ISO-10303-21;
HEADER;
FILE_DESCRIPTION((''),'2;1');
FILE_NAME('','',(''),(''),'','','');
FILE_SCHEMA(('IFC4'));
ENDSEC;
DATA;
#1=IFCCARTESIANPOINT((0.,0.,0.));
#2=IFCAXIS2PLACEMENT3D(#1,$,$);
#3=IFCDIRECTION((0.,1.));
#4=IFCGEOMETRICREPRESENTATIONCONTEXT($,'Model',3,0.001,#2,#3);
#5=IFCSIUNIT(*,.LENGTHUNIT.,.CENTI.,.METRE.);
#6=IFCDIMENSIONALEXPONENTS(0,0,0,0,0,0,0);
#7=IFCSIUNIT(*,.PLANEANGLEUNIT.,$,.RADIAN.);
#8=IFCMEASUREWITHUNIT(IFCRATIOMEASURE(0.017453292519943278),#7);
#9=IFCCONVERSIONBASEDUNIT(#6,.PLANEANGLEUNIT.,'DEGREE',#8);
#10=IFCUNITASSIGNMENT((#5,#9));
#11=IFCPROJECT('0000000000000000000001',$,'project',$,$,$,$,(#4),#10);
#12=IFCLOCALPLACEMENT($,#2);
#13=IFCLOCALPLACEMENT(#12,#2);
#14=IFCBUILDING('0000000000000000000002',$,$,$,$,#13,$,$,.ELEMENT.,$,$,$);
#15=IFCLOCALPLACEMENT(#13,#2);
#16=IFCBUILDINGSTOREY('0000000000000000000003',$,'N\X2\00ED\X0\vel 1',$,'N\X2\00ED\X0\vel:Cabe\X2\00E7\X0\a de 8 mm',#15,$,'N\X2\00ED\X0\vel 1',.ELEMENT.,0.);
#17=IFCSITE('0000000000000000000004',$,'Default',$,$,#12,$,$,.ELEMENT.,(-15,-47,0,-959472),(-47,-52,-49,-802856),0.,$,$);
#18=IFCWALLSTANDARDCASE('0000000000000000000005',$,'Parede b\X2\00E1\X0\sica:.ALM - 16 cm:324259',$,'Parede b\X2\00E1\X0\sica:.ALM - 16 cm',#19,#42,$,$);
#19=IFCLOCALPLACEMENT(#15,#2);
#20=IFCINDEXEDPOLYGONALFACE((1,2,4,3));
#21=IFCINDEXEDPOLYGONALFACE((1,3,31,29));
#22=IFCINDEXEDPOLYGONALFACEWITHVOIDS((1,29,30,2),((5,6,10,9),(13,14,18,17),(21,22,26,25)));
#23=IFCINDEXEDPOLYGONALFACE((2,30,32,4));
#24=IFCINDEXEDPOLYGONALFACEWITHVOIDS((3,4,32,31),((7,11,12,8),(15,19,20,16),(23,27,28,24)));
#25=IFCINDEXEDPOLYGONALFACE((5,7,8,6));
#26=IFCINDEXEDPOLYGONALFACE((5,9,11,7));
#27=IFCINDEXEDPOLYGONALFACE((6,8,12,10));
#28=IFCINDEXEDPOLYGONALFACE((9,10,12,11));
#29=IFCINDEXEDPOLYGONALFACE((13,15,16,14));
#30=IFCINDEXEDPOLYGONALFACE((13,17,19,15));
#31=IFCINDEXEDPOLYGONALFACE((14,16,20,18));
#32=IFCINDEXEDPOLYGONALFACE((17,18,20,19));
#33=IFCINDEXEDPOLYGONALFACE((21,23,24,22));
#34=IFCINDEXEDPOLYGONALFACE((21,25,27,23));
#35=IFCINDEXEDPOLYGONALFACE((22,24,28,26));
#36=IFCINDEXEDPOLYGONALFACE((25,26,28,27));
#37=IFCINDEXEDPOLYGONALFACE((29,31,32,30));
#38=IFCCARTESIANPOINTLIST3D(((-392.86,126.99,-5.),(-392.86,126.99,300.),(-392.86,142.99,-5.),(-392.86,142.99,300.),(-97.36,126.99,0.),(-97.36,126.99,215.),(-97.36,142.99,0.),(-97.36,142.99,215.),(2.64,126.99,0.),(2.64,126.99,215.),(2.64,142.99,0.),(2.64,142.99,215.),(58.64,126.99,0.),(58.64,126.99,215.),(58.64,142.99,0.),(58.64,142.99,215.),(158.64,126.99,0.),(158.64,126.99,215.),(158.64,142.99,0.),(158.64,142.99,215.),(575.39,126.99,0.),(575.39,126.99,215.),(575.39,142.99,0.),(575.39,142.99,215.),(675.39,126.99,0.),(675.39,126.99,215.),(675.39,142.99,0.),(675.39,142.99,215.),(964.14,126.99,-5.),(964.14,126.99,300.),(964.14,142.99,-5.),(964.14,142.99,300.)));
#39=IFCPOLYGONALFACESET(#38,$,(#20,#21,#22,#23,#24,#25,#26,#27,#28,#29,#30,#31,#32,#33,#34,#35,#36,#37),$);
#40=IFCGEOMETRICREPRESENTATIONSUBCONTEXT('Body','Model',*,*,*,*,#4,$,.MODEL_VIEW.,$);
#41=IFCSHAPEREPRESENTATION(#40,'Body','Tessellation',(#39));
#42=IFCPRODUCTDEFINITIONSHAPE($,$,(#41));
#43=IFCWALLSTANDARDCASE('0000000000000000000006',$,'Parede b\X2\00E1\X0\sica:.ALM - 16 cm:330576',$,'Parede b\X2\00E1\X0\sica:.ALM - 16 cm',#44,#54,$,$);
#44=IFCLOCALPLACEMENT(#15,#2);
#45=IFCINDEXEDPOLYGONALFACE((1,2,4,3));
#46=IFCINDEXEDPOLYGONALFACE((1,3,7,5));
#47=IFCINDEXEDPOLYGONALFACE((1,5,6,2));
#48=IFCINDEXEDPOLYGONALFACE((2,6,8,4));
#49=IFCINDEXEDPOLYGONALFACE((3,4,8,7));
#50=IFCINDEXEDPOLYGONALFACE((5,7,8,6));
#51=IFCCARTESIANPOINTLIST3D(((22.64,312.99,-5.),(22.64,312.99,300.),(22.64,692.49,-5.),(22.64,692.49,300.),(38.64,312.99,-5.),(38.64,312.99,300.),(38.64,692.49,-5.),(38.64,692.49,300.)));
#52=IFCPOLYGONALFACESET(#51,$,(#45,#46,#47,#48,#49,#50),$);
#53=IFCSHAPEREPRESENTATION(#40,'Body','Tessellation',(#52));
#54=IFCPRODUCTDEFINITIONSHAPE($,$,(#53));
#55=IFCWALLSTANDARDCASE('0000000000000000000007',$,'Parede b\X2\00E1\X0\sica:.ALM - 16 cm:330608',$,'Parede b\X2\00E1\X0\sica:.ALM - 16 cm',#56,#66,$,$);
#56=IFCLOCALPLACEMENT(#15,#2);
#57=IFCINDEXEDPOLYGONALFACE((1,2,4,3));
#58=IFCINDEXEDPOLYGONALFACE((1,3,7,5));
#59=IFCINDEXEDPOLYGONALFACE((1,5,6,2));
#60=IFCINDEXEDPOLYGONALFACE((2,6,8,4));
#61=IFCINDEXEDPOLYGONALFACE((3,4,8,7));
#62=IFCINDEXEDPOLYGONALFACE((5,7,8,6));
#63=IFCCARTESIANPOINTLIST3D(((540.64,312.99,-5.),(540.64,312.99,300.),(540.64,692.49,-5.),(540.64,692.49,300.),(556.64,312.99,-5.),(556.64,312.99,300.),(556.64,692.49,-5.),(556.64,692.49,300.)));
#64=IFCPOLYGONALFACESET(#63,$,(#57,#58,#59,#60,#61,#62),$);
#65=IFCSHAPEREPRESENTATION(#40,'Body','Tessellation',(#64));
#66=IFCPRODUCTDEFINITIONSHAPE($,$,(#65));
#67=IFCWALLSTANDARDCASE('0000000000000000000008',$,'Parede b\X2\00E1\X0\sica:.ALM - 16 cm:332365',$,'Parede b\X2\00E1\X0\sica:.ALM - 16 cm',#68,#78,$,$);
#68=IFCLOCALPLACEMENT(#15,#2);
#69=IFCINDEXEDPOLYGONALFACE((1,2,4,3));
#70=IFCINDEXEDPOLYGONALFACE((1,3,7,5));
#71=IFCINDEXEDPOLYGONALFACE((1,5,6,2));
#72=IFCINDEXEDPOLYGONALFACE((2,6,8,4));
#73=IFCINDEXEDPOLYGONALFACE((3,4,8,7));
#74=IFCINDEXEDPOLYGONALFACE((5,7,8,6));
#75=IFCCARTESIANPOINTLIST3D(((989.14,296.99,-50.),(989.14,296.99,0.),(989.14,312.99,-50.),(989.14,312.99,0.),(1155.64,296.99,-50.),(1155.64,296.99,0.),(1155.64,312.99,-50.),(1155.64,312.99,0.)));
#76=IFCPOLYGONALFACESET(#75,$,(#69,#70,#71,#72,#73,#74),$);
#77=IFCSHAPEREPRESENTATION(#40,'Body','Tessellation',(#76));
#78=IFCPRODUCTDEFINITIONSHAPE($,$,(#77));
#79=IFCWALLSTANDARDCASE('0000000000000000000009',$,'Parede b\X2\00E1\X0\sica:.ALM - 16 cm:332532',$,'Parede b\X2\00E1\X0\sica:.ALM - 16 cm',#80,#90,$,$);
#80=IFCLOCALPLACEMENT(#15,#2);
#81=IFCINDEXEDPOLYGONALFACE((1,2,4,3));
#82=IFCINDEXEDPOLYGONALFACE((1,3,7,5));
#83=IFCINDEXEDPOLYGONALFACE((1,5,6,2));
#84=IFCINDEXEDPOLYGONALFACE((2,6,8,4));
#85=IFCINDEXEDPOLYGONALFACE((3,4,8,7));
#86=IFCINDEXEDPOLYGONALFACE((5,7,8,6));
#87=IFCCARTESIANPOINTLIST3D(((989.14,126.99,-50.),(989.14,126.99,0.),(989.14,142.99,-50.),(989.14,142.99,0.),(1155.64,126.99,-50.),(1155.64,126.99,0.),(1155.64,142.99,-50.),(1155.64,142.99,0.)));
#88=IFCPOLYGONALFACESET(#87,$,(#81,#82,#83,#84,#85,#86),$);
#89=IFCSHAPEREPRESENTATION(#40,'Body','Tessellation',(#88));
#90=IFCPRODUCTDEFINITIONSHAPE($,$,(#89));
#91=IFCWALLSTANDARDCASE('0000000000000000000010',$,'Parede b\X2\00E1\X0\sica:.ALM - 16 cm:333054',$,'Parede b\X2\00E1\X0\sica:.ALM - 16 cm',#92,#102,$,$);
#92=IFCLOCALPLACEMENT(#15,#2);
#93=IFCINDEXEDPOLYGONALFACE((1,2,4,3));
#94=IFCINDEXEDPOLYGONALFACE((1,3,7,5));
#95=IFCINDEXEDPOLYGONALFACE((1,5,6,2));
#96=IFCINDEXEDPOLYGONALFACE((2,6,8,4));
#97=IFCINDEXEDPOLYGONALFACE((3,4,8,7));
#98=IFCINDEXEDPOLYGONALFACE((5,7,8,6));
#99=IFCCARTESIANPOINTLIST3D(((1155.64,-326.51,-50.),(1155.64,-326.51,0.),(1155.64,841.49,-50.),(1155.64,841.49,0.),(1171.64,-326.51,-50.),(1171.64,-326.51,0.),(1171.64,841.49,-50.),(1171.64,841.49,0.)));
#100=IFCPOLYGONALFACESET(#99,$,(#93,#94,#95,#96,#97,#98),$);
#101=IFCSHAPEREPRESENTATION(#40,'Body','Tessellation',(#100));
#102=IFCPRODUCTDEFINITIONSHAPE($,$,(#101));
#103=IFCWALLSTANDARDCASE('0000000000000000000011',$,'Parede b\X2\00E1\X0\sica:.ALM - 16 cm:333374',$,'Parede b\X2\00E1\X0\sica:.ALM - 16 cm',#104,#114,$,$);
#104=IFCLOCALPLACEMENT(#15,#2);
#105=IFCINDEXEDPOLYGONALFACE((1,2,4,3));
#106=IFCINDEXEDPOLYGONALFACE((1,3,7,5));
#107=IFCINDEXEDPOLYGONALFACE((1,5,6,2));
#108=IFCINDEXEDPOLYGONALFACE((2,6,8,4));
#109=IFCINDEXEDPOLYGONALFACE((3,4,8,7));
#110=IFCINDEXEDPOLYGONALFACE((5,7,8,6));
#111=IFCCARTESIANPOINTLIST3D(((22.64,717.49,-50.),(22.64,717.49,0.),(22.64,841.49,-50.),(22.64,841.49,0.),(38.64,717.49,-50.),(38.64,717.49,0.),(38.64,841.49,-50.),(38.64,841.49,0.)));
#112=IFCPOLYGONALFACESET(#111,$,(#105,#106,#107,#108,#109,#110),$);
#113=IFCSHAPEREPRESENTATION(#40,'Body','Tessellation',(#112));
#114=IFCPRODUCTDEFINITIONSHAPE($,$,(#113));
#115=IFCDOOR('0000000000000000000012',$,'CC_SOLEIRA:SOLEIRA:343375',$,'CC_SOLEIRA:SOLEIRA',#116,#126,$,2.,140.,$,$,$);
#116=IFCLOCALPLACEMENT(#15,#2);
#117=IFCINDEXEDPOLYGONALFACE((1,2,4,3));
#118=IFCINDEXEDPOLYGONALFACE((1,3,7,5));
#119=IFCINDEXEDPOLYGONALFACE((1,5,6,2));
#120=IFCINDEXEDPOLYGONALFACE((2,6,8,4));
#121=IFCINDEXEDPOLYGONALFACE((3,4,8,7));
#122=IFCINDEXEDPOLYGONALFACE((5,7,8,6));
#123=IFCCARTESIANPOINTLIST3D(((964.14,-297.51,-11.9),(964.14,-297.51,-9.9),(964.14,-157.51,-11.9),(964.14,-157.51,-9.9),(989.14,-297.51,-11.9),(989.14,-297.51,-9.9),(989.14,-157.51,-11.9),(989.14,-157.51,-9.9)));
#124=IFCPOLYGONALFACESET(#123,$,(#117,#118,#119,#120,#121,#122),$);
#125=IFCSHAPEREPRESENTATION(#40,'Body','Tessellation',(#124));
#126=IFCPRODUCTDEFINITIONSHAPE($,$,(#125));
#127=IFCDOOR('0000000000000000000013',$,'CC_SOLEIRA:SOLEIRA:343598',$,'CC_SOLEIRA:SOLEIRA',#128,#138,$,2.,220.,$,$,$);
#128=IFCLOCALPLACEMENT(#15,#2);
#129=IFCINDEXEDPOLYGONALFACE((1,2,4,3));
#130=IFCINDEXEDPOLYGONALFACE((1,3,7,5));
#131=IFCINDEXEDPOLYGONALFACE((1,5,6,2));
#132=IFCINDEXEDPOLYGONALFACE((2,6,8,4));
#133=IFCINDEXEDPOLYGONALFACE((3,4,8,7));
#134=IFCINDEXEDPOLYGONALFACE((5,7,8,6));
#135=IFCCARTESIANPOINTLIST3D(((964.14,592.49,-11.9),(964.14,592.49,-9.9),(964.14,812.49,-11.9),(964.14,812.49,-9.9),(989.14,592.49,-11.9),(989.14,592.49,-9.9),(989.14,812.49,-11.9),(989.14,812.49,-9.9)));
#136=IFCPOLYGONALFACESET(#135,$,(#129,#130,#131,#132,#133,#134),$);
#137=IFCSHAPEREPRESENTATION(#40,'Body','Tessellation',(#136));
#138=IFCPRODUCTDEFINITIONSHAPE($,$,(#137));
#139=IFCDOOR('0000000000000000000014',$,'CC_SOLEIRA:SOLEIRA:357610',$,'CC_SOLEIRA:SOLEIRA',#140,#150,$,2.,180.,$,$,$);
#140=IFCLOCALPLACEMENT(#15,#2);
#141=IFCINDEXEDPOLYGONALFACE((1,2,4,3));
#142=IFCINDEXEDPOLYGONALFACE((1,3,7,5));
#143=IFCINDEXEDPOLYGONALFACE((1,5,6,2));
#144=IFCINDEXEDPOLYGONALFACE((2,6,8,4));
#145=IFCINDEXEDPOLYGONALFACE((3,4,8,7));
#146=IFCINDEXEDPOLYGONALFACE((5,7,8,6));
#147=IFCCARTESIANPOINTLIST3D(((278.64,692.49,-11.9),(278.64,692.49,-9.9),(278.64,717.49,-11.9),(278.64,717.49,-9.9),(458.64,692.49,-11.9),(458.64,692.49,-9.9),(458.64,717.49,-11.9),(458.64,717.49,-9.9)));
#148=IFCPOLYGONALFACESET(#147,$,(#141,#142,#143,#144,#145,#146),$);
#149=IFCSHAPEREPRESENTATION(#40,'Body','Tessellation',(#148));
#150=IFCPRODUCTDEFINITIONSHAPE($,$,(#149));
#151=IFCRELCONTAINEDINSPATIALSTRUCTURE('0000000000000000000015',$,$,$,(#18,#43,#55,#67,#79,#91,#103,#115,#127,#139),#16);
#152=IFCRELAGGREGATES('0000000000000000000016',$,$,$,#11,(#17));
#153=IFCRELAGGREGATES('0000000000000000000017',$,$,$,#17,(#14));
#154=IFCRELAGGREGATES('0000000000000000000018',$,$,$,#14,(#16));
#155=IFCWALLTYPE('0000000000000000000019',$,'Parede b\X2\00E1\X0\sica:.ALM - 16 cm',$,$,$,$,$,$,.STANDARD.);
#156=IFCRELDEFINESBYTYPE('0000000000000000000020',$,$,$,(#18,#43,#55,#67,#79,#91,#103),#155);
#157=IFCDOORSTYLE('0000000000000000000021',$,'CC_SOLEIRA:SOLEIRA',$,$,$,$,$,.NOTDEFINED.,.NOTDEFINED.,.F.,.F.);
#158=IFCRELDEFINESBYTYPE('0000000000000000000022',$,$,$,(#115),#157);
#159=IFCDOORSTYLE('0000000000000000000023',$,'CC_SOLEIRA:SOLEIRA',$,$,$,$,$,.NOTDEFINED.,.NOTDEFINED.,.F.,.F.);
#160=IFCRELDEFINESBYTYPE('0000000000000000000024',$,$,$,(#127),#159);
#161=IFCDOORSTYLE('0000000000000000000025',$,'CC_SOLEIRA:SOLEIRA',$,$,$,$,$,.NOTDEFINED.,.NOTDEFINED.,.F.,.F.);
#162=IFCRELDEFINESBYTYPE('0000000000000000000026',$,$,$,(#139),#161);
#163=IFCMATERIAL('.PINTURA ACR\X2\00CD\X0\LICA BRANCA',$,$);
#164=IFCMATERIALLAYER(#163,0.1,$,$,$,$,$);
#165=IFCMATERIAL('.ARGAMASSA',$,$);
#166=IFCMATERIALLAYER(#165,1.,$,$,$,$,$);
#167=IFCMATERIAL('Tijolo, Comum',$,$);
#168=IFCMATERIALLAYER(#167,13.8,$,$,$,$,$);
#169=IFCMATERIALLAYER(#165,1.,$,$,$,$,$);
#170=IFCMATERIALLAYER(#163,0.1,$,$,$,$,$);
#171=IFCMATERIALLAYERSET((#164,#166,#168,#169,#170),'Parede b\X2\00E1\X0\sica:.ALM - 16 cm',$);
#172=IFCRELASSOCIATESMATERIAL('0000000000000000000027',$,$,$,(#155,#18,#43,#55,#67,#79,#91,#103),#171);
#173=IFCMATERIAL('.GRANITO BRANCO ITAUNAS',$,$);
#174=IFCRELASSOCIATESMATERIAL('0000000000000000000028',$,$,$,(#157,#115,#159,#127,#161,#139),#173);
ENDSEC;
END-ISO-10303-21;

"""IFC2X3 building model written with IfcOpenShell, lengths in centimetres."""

from ifc_helpers import new_model, entity, si_unit, converted_unit, direction, frame, frame_2d, origin, origin_2d_with_axis, place, context, subcontext, project, spatial, rectangle, extrude, source, transform, mapped, material, layer, layer_set, layer_usage, type_object, type_shapes, element, save


model = new_model("IFC2X3")

# Units and contexts
model_context = context("Model", 3, precision=0.001, world=origin(), true_north=direction((0.0, 1.0)))
body_context = subcontext(model_context, "Body", "Model", "MODEL_VIEW")
ifc_project = project(units=[si_unit("LENGTHUNIT", "METRE", prefix="CENTI"), converted_unit("PLANEANGLEUNIT", "DEGREE", entity("IfcRatioMeasure", 0.017453292519943278), si_unit("PLANEANGLEUNIT", "RADIAN"), dimensions=[0, 0, 0, 0, 0, 0, 0])], contexts=[model_context])

# Site, building, storey
site_placement = place(None, origin())
site = spatial("IfcSite", under=ifc_project, at=site_placement, Name="Default", CompositionType="ELEMENT", RefLatitude=(-15, -47, 0, -959472), RefLongitude=(-47, -52, -49, -802856), RefElevation=0.0)
building_placement = place(site_placement, origin())
building = spatial("IfcBuilding", under=site, at=building_placement, CompositionType="ELEMENT")
storey_placement = place(building_placement, origin())
storey = spatial("IfcBuildingStorey", under=building, at=storey_placement, Name="Nível 1", ObjectType="Nível:Cabeça de 8 mm", LongName="Nível 1", CompositionType="ELEMENT", Elevation=0.0)

# Shared definitions
ifc_material_1 = material(Name=".PINTURA ACRÍLICA BRANCA")
ifc_material_2 = material(Name=".ARGAMASSA")
ifc_material_3 = material(Name="Tijolo, Comum")

# Shared definitions
ifc_layer_1 = layer(ifc_material_1, 0.1)
ifc_layer_2 = layer(ifc_material_2, 1.0)
ifc_layer_3 = layer(ifc_material_3, 13.8)
ifc_layer_4 = layer(ifc_material_2, 1.0)
ifc_layer_5 = layer(ifc_material_1, 0.1)
ifc_layer_set_1 = layer_set([ifc_layer_1, ifc_layer_2, ifc_layer_3, ifc_layer_4, ifc_layer_5], Name="Parede básica:.ALM - 16 cm")
ifc_layer_usage_1 = layer_usage(ifc_layer_set_1, "AXIS2", "NEGATIVE", 8.0)
wall_type_1 = type_object("IfcWallType", Name="Parede básica:.ALM - 16 cm", PredefinedType="STANDARD", material=ifc_layer_set_1)

# Wall, openings
wall_1_placement = place(storey_placement, frame((964.14, 134.99, -5.0), z_axis=(0.0, 0.0, 1.0), x_axis=(-1.0, 0.0, 0.0)))
wall_1 = element("IfcWallStandardCase", 1, at=wall_1_placement, inside=storey, type_object=wall_type_1, material=ifc_layer_usage_1, Name="Parede básica:.ALM - 16 cm:324259", ObjectType="Parede básica:.ALM - 16 cm", context=body_context, shape_type="SweptSolid", body=[
    extrude(rectangle(XDim=1357.0, YDim=16.0, at=frame_2d((678.5, 0.0), x_axis=(-1.0, 0.0))), origin(), (0.0, 0.0, 1.0), 305.0),
])
opening_1_placement = place(wall_1_placement, frame((288.75, -8.0, 5.0)))
element("IfcOpeningElement", 2, at=opening_1_placement, cuts=wall_1, ObjectType="Opening", context=body_context, shape_type="SweptSolid", body=[
    extrude(rectangle(XDim=215.0, YDim=100.0, at=frame_2d((107.5, 50.0), x_axis=(1.0, 0.0))), frame((0.0, 0.0, 0.0), z_axis=(0.0, 1.0, 0.0), x_axis=(0.0, 0.0, 1.0)), (0.0, 0.0, 1.0), 16.0),
])
opening_2_placement = place(wall_1_placement, frame((805.5, -8.0, 5.0)))
element("IfcOpeningElement", 3, at=opening_2_placement, cuts=wall_1, ObjectType="Opening", context=body_context, shape_type="SweptSolid", body=[
    extrude(rectangle(XDim=215.0, YDim=100.0, at=frame_2d((107.5, 50.0), x_axis=(1.0, 0.0))), frame((0.0, 0.0, 0.0), z_axis=(0.0, 1.0, 0.0), x_axis=(0.0, 0.0, 1.0)), (0.0, 0.0, 1.0), 16.0),
])
opening_3_placement = place(wall_1_placement, frame((961.5, -8.0, 5.0)))
element("IfcOpeningElement", 4, at=opening_3_placement, cuts=wall_1, ObjectType="Opening", context=body_context, shape_type="SweptSolid", body=[
    extrude(rectangle(XDim=215.0, YDim=100.0, at=frame_2d((107.5, 50.0), x_axis=(1.0, 0.0))), frame((0.0, 0.0, 0.0), z_axis=(0.0, 1.0, 0.0), x_axis=(0.0, 0.0, 1.0)), (0.0, 0.0, 1.0), 16.0),
])

# Walls
wall_2_placement = place(storey_placement, frame((30.64, 312.99, -5.0), z_axis=(0.0, 0.0, 1.0), x_axis=(0.0, 1.0, 0.0)))
element("IfcWallStandardCase", 5, at=wall_2_placement, inside=storey, type_object=wall_type_1, material=ifc_layer_usage_1, Name="Parede básica:.ALM - 16 cm:330576", ObjectType="Parede básica:.ALM - 16 cm", context=body_context, shape_type="SweptSolid", body=[
    extrude(rectangle(XDim=379.5, YDim=16.0, at=frame_2d((189.75, 0.0), x_axis=(-1.0, 0.0))), origin(), (0.0, 0.0, 1.0), 305.0),
])
wall_3_placement = place(storey_placement, frame((548.64, 312.99, -5.0), z_axis=(0.0, 0.0, 1.0), x_axis=(0.0, 1.0, 0.0)))
element("IfcWallStandardCase", 6, at=wall_3_placement, inside=storey, type_object=wall_type_1, material=ifc_layer_usage_1, Name="Parede básica:.ALM - 16 cm:330608", ObjectType="Parede básica:.ALM - 16 cm", context=body_context, shape_type="SweptSolid", body=[
    extrude(rectangle(XDim=379.5, YDim=16.0, at=frame_2d((189.75, 0.0), x_axis=(-1.0, 0.0))), origin(), (0.0, 0.0, 1.0), 305.0),
])
wall_4_placement = place(storey_placement, frame((989.14, 304.99, -50.0)))
element("IfcWallStandardCase", 7, at=wall_4_placement, inside=storey, type_object=wall_type_1, material=ifc_layer_usage_1, Name="Parede básica:.ALM - 16 cm:332365", ObjectType="Parede básica:.ALM - 16 cm", context=body_context, shape_type="SweptSolid", body=[
    extrude(rectangle(XDim=166.5, YDim=16.0, at=frame_2d((83.25, 0.0), x_axis=(-1.0, 0.0))), origin(), (0.0, 0.0, 1.0), 50.0),
])
wall_5_placement = place(storey_placement, frame((989.14, 134.99, -50.0)))
element("IfcWallStandardCase", 8, at=wall_5_placement, inside=storey, type_object=wall_type_1, material=ifc_layer_usage_1, Name="Parede básica:.ALM - 16 cm:332532", ObjectType="Parede básica:.ALM - 16 cm", context=body_context, shape_type="SweptSolid", body=[
    extrude(rectangle(XDim=166.5, YDim=16.0, at=frame_2d((83.25, 0.0), x_axis=(-1.0, 0.0))), origin(), (0.0, 0.0, 1.0), 50.0),
])
wall_6_placement = place(storey_placement, frame((1163.64, -326.51, -50.0), z_axis=(0.0, 0.0, 1.0), x_axis=(0.0, 1.0, 0.0)))
element("IfcWallStandardCase", 9, at=wall_6_placement, inside=storey, type_object=wall_type_1, material=ifc_layer_usage_1, Name="Parede básica:.ALM - 16 cm:333054", ObjectType="Parede básica:.ALM - 16 cm", context=body_context, shape_type="SweptSolid", body=[
    extrude(rectangle(XDim=1168.0, YDim=16.0, at=frame_2d((584.0, 0.0), x_axis=(-1.0, 0.0))), origin(), (0.0, 0.0, 1.0), 50.0),
])
wall_7_placement = place(storey_placement, frame((30.64, 717.49, -50.0), z_axis=(0.0, 0.0, 1.0), x_axis=(0.0, 1.0, 0.0)))
element("IfcWallStandardCase", 10, at=wall_7_placement, inside=storey, type_object=wall_type_1, material=ifc_layer_usage_1, Name="Parede básica:.ALM - 16 cm:333374", ObjectType="Parede básica:.ALM - 16 cm", context=body_context, shape_type="SweptSolid", body=[
    extrude(rectangle(XDim=124.0, YDim=16.0, at=frame_2d((62.0, 0.0), x_axis=(-1.0, 0.0))), origin(), (0.0, 0.0, 1.0), 50.0),
])

# Doors
ifc_material_4 = material(Name=".GRANITO BRANCO ITAUNAS")
door_style_1 = type_object("IfcDoorStyle", Name="CC_SOLEIRA:SOLEIRA", ConstructionType="NOTDEFINED", OperationType="NOTDEFINED", ParameterTakesPrecedence=False, Sizeable=False, material=ifc_material_4)
shared_shape_1 = source(origin(), body_context, "Body", "SweptSolid", [
    extrude(rectangle(XDim=25.0, YDim=140.0, at=origin_2d_with_axis()), frame((70.0, 12.5, 0.0), z_axis=(0.0, 0.0, 1.0), x_axis=(0.0, -1.0, 0.0)), (0.0, 0.0, 1.0), 2.0),
])
type_shapes(door_style_1, [shared_shape_1])
door_1_placement = place(storey_placement, frame((964.14, -157.51, -11.9), z_axis=(0.0, 0.0, 1.0), x_axis=(0.0, -1.0, 0.0)))
element("IfcDoor", 11, at=door_1_placement, inside=storey, type_object=door_style_1, material=ifc_material_4, Name="CC_SOLEIRA:SOLEIRA:343375", ObjectType="CC_SOLEIRA:SOLEIRA", OverallHeight=2.0, OverallWidth=140.0, context=body_context, shape_type="MappedRepresentation", body=[
    mapped(shared_shape_1, transform((0.0, 0.0, 0.0), scale=1.0)),
])
door_style_2 = type_object("IfcDoorStyle", Name="CC_SOLEIRA:SOLEIRA", ConstructionType="NOTDEFINED", OperationType="NOTDEFINED", ParameterTakesPrecedence=False, Sizeable=False, material=ifc_material_4)
shared_shape_2 = source(origin(), body_context, "Body", "SweptSolid", [
    extrude(rectangle(XDim=220.0, YDim=25.0, at=origin_2d_with_axis()), frame((110.0, 12.5, 0.0), z_axis=(0.0, 0.0, 1.0), x_axis=(-1.0, 0.0, 0.0)), (0.0, 0.0, 1.0), 2.0),
])
type_shapes(door_style_2, [shared_shape_2])
door_2_placement = place(storey_placement, frame((964.14, 812.49, -11.9), z_axis=(0.0, 0.0, 1.0), x_axis=(0.0, -1.0, 0.0)))
element("IfcDoor", 12, at=door_2_placement, inside=storey, type_object=door_style_2, material=ifc_material_4, Name="CC_SOLEIRA:SOLEIRA:343598", ObjectType="CC_SOLEIRA:SOLEIRA", OverallHeight=2.0, OverallWidth=220.0, context=body_context, shape_type="MappedRepresentation", body=[
    mapped(shared_shape_2, transform((0.0, 0.0, 0.0), scale=1.0)),
])
door_style_3 = type_object("IfcDoorStyle", Name="CC_SOLEIRA:SOLEIRA", ConstructionType="NOTDEFINED", OperationType="NOTDEFINED", ParameterTakesPrecedence=False, Sizeable=False, material=ifc_material_4)
shared_shape_3 = source(origin(), body_context, "Body", "SweptSolid", [
    extrude(rectangle(XDim=180.0, YDim=25.0, at=origin_2d_with_axis()), frame((90.0, 12.5, 0.0), z_axis=(0.0, 0.0, 1.0), x_axis=(-1.0, 0.0, 0.0)), (0.0, 0.0, 1.0), 2.0),
])
type_shapes(door_style_3, [shared_shape_3])
door_3_placement = place(storey_placement, frame((278.64, 692.49, -11.9)))
element("IfcDoor", 13, at=door_3_placement, inside=storey, type_object=door_style_3, material=ifc_material_4, Name="CC_SOLEIRA:SOLEIRA:357610", ObjectType="CC_SOLEIRA:SOLEIRA", OverallHeight=2.0, OverallWidth=180.0, context=body_context, shape_type="MappedRepresentation", body=[
    mapped(shared_shape_3, transform((0.0, 0.0, 0.0), scale=1.0)),
])

save(model, "model.ifc")
